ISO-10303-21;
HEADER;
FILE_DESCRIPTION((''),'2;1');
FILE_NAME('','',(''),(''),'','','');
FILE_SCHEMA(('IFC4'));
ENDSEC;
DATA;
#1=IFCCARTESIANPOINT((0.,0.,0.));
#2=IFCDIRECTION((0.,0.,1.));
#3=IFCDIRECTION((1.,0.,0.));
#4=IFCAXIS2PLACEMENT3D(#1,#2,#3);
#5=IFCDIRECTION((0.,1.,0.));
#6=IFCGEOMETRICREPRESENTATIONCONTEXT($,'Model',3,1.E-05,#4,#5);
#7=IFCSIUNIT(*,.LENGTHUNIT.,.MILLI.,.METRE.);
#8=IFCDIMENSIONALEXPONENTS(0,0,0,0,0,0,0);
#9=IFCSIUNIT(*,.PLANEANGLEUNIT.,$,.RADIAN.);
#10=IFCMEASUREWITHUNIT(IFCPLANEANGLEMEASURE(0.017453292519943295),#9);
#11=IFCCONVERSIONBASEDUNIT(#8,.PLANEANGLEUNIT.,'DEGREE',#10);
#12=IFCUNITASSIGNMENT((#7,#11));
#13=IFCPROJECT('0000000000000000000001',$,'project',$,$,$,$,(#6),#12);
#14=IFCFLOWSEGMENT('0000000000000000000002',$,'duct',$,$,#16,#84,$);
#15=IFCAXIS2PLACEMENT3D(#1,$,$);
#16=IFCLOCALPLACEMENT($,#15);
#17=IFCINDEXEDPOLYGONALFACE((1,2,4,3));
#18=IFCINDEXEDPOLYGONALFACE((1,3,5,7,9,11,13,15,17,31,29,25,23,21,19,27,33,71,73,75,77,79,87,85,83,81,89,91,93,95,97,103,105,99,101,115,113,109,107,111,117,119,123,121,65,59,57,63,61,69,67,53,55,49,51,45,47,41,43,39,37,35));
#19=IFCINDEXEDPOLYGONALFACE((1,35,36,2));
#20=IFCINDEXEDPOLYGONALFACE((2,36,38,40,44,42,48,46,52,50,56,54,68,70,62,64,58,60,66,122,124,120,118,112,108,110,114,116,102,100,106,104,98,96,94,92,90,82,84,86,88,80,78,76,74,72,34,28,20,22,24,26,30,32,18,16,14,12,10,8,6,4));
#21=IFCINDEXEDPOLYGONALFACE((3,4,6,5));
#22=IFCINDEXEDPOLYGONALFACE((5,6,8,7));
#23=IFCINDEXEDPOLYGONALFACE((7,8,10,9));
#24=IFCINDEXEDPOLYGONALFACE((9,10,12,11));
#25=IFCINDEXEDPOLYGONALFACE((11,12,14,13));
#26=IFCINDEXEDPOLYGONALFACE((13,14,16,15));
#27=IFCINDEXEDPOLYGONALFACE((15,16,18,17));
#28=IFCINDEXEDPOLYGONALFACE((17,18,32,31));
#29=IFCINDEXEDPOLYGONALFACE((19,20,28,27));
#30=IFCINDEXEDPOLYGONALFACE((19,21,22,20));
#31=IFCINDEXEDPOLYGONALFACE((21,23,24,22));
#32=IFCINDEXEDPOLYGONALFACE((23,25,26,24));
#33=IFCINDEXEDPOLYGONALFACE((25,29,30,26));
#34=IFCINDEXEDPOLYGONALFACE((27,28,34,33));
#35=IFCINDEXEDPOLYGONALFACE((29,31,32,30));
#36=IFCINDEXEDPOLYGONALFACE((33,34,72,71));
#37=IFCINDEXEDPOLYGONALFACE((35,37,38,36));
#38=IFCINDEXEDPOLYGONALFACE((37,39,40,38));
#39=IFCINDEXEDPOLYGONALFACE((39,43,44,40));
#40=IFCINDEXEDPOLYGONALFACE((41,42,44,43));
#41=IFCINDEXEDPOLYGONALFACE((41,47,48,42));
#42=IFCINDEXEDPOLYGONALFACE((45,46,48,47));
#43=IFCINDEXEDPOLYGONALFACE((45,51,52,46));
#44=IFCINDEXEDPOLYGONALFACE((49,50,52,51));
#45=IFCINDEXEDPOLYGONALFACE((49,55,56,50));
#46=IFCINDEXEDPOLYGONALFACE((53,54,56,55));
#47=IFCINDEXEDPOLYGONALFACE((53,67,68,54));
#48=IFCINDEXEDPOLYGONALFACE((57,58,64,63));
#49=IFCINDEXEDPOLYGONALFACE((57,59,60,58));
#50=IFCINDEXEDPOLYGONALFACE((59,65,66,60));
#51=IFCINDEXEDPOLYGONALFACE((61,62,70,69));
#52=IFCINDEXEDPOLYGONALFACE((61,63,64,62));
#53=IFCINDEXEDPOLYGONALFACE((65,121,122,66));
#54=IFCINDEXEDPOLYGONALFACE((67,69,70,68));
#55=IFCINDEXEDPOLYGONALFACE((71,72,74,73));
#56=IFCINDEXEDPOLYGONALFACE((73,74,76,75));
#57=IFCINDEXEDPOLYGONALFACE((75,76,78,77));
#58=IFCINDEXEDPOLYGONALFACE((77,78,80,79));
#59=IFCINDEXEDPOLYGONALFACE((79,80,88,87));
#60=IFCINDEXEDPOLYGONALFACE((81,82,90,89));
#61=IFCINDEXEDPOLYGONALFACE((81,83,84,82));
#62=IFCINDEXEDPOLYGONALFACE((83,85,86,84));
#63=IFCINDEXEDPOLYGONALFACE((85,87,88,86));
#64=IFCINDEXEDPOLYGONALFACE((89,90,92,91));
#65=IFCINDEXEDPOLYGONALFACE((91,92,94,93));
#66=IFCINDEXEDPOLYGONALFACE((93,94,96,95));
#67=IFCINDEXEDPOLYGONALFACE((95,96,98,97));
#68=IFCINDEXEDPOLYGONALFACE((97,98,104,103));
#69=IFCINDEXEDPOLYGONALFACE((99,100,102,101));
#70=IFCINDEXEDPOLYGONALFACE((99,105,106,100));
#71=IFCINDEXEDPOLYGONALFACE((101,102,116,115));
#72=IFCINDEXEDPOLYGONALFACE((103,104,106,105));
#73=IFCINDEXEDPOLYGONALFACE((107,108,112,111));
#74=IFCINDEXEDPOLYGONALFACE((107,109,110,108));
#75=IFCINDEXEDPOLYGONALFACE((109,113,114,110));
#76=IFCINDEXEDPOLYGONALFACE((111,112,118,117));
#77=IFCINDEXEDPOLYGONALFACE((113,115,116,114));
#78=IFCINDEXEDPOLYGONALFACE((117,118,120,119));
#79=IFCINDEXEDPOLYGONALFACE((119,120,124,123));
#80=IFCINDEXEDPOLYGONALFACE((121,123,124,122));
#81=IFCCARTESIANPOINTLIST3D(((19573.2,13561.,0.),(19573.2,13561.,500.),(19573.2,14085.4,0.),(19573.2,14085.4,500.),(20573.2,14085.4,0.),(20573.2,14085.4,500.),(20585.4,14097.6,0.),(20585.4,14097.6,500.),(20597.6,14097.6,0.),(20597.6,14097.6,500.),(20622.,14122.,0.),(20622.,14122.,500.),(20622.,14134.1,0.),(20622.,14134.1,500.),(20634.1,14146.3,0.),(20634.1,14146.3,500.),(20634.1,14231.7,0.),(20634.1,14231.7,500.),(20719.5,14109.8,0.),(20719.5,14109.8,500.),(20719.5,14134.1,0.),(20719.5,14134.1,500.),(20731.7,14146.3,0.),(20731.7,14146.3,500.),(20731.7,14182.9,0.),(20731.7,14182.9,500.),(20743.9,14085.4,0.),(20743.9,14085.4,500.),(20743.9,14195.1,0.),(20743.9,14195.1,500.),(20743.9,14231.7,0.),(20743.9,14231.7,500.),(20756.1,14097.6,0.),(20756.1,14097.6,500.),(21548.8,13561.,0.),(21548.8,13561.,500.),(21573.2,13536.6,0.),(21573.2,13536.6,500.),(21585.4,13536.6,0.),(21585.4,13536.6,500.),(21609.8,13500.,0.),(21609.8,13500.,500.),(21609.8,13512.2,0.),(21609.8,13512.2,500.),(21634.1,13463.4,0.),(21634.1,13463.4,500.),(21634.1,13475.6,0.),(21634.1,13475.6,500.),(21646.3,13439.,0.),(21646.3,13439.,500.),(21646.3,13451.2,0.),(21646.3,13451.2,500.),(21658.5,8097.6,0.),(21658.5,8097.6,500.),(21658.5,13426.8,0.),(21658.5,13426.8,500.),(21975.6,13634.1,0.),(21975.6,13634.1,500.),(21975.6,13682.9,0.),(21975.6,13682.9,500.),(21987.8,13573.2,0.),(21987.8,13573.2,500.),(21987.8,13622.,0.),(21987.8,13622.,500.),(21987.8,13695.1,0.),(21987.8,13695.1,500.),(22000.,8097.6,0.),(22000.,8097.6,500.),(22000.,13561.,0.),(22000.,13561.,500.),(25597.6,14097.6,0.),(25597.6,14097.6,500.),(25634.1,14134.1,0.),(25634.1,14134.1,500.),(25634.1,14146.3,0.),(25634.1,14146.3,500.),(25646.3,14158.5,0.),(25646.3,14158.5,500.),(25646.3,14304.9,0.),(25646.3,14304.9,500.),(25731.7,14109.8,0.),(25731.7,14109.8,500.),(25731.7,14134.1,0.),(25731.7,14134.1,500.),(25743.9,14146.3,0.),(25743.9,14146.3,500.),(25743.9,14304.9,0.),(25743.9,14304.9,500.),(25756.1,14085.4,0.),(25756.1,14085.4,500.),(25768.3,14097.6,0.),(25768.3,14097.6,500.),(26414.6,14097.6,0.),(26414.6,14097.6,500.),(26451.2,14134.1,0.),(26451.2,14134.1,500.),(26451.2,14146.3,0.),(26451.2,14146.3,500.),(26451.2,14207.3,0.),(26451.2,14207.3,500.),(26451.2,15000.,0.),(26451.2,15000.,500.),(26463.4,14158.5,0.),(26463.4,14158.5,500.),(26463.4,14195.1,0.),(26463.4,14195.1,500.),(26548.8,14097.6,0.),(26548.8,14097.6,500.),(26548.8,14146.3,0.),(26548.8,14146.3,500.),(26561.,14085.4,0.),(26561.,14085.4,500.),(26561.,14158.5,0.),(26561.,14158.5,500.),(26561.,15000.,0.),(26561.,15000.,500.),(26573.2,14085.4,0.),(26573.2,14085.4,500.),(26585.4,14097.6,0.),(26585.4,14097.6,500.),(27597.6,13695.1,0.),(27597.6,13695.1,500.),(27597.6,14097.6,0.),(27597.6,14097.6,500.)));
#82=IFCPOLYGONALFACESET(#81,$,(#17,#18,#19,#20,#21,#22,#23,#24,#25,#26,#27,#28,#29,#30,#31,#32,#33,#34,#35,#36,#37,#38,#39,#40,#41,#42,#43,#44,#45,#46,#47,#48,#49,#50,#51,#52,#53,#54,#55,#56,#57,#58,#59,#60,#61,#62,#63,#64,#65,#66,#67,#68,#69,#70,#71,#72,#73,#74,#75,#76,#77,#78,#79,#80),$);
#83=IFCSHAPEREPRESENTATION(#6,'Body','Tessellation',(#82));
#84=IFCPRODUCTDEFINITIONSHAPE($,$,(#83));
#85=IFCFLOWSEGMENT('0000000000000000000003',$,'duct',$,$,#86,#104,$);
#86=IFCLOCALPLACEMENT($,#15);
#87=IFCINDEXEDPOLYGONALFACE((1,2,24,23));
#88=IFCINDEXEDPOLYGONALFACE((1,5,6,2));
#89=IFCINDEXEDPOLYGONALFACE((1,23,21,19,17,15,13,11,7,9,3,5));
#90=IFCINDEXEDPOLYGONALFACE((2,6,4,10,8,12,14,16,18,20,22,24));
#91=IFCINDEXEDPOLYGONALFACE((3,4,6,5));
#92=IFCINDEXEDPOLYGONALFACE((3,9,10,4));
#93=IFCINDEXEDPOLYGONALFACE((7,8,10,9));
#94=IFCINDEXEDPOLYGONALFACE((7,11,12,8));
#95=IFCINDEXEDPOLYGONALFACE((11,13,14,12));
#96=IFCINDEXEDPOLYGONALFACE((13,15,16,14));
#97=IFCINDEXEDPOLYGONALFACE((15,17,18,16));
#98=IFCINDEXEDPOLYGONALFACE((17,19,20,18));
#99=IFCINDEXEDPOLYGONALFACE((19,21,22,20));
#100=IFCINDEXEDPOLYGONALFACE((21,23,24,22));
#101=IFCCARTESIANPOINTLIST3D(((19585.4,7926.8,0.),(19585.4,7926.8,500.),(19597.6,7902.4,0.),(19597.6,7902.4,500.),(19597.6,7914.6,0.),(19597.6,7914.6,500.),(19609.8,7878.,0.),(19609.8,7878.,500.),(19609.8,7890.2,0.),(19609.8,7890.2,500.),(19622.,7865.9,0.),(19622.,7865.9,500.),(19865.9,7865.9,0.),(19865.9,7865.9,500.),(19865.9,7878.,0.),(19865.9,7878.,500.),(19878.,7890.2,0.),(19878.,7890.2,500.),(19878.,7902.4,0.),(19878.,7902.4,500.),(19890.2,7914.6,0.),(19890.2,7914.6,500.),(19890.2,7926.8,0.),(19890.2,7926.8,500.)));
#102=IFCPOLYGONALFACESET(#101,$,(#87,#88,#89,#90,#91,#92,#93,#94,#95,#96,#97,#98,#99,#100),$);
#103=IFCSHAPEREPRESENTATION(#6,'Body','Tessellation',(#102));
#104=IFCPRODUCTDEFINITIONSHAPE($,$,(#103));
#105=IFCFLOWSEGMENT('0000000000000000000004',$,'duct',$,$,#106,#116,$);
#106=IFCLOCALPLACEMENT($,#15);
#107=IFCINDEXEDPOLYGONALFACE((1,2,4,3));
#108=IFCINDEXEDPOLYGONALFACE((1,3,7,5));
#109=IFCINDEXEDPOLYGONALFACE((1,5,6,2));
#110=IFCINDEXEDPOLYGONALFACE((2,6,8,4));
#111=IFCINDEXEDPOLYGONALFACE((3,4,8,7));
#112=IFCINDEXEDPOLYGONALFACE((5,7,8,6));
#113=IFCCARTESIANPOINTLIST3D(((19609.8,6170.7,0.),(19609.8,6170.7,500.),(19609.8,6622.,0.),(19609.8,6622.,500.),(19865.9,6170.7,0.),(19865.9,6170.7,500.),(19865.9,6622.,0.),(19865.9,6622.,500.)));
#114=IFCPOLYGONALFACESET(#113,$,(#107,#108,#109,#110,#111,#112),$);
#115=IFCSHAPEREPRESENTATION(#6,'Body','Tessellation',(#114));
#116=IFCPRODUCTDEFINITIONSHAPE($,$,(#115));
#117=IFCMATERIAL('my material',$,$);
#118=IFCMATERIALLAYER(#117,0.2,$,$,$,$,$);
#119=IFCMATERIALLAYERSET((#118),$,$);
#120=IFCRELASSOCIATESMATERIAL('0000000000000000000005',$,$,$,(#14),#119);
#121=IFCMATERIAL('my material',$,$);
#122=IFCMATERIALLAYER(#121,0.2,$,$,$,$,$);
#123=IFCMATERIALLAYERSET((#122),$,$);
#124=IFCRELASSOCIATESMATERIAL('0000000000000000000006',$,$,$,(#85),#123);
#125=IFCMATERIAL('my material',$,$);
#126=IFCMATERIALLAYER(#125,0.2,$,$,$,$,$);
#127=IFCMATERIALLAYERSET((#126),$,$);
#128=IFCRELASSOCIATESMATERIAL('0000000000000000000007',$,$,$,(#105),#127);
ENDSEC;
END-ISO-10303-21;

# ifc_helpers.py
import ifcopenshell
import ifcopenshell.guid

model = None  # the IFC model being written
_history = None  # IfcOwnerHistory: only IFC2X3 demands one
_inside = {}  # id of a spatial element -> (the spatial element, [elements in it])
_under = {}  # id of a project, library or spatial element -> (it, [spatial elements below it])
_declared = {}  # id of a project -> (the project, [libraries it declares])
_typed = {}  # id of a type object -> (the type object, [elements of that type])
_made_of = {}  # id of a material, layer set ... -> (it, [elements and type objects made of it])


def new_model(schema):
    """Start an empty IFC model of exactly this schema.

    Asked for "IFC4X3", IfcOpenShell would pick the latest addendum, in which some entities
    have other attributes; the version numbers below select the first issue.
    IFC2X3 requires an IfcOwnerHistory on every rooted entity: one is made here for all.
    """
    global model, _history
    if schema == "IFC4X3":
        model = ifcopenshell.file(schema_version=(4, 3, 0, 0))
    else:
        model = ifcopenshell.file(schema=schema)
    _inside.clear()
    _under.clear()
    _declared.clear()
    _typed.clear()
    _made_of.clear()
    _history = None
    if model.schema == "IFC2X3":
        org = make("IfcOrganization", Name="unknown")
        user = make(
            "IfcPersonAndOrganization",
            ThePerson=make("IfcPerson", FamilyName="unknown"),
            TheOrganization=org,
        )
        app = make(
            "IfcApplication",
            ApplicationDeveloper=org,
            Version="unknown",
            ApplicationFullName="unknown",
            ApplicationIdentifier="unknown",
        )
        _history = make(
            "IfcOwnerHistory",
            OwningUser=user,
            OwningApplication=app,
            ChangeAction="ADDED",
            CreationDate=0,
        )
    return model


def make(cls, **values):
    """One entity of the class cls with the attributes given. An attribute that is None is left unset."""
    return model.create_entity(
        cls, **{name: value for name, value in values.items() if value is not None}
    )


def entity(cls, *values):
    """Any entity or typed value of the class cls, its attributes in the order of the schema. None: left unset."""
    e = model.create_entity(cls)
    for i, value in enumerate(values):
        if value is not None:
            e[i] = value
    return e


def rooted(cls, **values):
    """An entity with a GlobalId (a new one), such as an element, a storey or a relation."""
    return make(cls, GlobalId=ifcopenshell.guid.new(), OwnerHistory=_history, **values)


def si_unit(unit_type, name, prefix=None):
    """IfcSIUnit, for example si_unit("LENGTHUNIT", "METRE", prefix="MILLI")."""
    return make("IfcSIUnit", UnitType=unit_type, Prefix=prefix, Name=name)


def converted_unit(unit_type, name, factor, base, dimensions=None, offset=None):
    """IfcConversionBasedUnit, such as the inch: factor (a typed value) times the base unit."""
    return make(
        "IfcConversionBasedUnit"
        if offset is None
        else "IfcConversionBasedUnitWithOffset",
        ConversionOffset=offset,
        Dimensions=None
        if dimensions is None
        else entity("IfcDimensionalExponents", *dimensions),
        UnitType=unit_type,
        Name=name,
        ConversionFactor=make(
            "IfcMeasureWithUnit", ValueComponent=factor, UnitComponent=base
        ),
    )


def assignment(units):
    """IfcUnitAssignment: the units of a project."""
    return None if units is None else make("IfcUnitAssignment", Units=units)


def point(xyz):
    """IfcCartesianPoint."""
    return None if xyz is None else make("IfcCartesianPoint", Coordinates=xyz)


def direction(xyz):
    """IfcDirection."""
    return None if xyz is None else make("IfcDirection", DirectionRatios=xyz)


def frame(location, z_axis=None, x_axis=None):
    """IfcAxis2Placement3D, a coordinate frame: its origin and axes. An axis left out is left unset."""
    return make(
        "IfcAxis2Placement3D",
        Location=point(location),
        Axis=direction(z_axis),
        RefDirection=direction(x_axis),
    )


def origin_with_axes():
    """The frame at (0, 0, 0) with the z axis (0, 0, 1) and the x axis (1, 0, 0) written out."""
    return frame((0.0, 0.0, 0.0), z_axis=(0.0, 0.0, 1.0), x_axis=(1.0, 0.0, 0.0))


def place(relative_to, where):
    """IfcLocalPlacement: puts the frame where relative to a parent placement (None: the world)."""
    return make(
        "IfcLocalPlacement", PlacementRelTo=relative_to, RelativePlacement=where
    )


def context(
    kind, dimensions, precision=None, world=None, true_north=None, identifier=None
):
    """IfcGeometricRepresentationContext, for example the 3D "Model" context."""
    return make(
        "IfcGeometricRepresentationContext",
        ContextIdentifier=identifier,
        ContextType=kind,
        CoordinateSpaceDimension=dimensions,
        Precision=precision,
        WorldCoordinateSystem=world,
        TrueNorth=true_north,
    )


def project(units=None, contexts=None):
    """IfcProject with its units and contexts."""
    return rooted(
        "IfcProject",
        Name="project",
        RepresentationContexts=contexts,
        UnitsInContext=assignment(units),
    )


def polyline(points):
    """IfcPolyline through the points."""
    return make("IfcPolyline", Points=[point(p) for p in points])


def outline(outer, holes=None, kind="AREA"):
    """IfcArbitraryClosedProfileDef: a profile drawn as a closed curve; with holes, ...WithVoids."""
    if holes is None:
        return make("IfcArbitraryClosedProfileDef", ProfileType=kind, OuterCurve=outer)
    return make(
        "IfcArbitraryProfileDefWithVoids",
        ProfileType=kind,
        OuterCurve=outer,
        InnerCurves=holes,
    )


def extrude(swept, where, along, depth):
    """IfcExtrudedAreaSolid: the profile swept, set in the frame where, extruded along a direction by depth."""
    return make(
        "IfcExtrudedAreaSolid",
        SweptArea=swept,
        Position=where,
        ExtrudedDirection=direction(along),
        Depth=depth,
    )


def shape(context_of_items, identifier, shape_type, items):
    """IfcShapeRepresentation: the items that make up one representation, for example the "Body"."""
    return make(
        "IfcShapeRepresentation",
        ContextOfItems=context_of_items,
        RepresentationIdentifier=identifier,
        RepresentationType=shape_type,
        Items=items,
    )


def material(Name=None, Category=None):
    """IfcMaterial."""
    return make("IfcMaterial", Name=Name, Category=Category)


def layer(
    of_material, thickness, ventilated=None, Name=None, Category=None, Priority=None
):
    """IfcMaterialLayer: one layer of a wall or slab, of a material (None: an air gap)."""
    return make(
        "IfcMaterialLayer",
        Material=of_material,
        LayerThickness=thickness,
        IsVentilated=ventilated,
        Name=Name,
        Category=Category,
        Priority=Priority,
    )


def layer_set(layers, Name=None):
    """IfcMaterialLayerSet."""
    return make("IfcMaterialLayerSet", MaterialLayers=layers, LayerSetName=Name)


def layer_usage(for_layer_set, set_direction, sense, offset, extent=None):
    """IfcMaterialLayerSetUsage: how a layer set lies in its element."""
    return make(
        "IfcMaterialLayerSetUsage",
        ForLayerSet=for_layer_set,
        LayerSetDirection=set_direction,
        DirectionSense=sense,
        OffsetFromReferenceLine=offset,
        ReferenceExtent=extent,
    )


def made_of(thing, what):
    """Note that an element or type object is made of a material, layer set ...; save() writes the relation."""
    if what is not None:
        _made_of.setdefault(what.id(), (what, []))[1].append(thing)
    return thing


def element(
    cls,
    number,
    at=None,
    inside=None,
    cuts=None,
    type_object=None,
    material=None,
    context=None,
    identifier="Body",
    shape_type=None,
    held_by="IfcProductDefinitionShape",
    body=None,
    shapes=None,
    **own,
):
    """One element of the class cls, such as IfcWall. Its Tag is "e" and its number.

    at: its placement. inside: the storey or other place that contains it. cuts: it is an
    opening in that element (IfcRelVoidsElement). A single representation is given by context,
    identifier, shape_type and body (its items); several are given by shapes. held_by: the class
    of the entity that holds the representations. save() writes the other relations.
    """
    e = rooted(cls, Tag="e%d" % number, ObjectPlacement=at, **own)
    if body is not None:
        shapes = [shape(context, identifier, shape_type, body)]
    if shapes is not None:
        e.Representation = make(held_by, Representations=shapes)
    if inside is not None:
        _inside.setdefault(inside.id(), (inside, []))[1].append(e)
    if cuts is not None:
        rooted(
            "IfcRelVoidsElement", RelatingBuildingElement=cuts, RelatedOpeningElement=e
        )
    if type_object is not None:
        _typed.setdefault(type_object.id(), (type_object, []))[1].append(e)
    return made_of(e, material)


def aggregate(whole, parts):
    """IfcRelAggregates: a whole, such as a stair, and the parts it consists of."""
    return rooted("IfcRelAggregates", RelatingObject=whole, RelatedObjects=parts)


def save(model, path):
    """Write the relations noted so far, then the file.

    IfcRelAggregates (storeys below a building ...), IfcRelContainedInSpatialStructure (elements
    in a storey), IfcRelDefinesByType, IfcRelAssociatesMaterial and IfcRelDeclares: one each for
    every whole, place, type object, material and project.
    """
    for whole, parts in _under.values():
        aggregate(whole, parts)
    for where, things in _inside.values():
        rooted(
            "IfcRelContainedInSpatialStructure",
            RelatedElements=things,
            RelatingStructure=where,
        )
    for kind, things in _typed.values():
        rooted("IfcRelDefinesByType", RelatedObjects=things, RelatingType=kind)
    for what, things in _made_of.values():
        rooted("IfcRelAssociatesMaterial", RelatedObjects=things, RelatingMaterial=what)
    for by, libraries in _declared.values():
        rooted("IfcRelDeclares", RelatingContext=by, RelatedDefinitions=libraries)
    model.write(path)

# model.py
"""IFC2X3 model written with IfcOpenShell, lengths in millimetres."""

from ifc_helpers import new_model, entity, si_unit, converted_unit, direction, origin_with_axes, place, context, project, polyline, outline, extrude, material, layer, layer_set, layer_usage, element, save


model = new_model("IFC2X3")

# Units and contexts
model_context = context("Model", 3, precision=1e-05, world=origin_with_axes(), true_north=direction((0.0, 1.0, 0.0)))
ifc_project = project(units=[si_unit("LENGTHUNIT", "METRE", prefix="MILLI"), converted_unit("PLANEANGLEUNIT", "DEGREE", entity("IfcPlaneAngleMeasure", 0.017453292519943295), si_unit("PLANEANGLEUNIT", "RADIAN"), dimensions=[0, 0, 0, 0, 0, 0, 0])], contexts=[model_context])

# Flow segments
ifc_material_1 = material(Name="my material")
ifc_layer_1 = layer(ifc_material_1, 0.2)
ifc_layer_set_1 = layer_set([ifc_layer_1])
ifc_layer_usage_1 = layer_usage(ifc_layer_set_1, "AXIS2", "POSITIVE", -0.1)
flow_segment_1_placement = place(None, origin_with_axes())
element("IfcFlowSegment", 1, at=flow_segment_1_placement, material=ifc_layer_usage_1, Name="duct", context=model_context, shape_type="SweptSolid", body=[
    extrude(outline(polyline([(19573.2, 13561.0), (21548.8, 13561.0), (21573.2, 13536.6), (21585.4, 13536.6), (21609.8, 13512.2), (21609.8, 13500.0), (21634.1, 13475.6), (21634.1, 13463.4), (21646.3, 13451.2), (21646.3, 13439.0), (21658.5, 13426.8), (21658.5, 8097.6), (22000.0, 8097.6), (22000.0, 13561.0), (21987.8, 13573.2), (21987.8, 13622.0), (21975.6, 13634.1), (21975.6, 13682.9), (21987.8, 13695.1), (27597.6, 13695.1), (27597.6, 14097.6), (26585.4, 14097.6), (26573.2, 14085.4), (26561.0, 14085.4), (26548.8, 14097.6), (26548.8, 14146.3), (26561.0, 14158.5), (26561.0, 15000.0), (26451.2, 15000.0), (26451.2, 14207.3), (26463.4, 14195.1), (26463.4, 14158.5), (26451.2, 14146.3), (26451.2, 14134.1), (26414.6, 14097.6), (25768.3, 14097.6), (25756.1, 14085.4), (25731.7, 14109.8), (25731.7, 14134.1), (25743.9, 14146.3), (25743.9, 14304.9), (25646.3, 14304.9), (25646.3, 14158.5), (25634.1, 14146.3), (25634.1, 14134.1), (25597.6, 14097.6), (20756.1, 14097.6), (20743.9, 14085.4), (20719.5, 14109.8), (20719.5, 14134.1), (20731.7, 14146.3), (20731.7, 14182.9), (20743.9, 14195.1), (20743.9, 14231.7), (20634.1, 14231.7), (20634.1, 14146.3), (20622.0, 14134.1), (20622.0, 14122.0), (20597.6, 14097.6), (20585.4, 14097.6), (20573.2, 14085.4), (19573.2, 14085.4), (19573.2, 13561.0)])), origin_with_axes(), (0.0, 0.0, 1.0), 500.0),
])
ifc_material_2 = material(Name="my material")
ifc_layer_2 = layer(ifc_material_2, 0.2)
ifc_layer_set_2 = layer_set([ifc_layer_2])
ifc_layer_usage_2 = layer_usage(ifc_layer_set_2, "AXIS2", "POSITIVE", -0.1)
flow_segment_2_placement = place(None, origin_with_axes())
element("IfcFlowSegment", 2, at=flow_segment_2_placement, material=ifc_layer_usage_2, Name="duct", context=model_context, shape_type="SweptSolid", body=[
    extrude(outline(polyline([(19585.4, 7926.8), (19597.6, 7914.6), (19597.6, 7902.4), (19609.8, 7890.2), (19609.8, 7878.0), (19622.0, 7865.9), (19865.9, 7865.9), (19865.9, 7878.0), (19878.0, 7890.2), (19878.0, 7902.4), (19890.2, 7914.6), (19890.2, 7926.8), (19585.4, 7926.8)])), origin_with_axes(), (0.0, 0.0, 1.0), 500.0),
])
ifc_material_3 = material(Name="my material")
ifc_layer_3 = layer(ifc_material_3, 0.2)
ifc_layer_set_3 = layer_set([ifc_layer_3])
ifc_layer_usage_3 = layer_usage(ifc_layer_set_3, "AXIS2", "POSITIVE", -0.1)
flow_segment_3_placement = place(None, origin_with_axes())
element("IfcFlowSegment", 3, at=flow_segment_3_placement, material=ifc_layer_usage_3, Name="duct", context=model_context, shape_type="SweptSolid", body=[
    extrude(outline(polyline([(19609.8, 6170.7), (19865.9, 6170.7), (19865.9, 6622.0), (19609.8, 6622.0), (19609.8, 6170.7)])), origin_with_axes(), (0.0, 0.0, 1.0), 500.0),
])

save(model, "model.ifc")
